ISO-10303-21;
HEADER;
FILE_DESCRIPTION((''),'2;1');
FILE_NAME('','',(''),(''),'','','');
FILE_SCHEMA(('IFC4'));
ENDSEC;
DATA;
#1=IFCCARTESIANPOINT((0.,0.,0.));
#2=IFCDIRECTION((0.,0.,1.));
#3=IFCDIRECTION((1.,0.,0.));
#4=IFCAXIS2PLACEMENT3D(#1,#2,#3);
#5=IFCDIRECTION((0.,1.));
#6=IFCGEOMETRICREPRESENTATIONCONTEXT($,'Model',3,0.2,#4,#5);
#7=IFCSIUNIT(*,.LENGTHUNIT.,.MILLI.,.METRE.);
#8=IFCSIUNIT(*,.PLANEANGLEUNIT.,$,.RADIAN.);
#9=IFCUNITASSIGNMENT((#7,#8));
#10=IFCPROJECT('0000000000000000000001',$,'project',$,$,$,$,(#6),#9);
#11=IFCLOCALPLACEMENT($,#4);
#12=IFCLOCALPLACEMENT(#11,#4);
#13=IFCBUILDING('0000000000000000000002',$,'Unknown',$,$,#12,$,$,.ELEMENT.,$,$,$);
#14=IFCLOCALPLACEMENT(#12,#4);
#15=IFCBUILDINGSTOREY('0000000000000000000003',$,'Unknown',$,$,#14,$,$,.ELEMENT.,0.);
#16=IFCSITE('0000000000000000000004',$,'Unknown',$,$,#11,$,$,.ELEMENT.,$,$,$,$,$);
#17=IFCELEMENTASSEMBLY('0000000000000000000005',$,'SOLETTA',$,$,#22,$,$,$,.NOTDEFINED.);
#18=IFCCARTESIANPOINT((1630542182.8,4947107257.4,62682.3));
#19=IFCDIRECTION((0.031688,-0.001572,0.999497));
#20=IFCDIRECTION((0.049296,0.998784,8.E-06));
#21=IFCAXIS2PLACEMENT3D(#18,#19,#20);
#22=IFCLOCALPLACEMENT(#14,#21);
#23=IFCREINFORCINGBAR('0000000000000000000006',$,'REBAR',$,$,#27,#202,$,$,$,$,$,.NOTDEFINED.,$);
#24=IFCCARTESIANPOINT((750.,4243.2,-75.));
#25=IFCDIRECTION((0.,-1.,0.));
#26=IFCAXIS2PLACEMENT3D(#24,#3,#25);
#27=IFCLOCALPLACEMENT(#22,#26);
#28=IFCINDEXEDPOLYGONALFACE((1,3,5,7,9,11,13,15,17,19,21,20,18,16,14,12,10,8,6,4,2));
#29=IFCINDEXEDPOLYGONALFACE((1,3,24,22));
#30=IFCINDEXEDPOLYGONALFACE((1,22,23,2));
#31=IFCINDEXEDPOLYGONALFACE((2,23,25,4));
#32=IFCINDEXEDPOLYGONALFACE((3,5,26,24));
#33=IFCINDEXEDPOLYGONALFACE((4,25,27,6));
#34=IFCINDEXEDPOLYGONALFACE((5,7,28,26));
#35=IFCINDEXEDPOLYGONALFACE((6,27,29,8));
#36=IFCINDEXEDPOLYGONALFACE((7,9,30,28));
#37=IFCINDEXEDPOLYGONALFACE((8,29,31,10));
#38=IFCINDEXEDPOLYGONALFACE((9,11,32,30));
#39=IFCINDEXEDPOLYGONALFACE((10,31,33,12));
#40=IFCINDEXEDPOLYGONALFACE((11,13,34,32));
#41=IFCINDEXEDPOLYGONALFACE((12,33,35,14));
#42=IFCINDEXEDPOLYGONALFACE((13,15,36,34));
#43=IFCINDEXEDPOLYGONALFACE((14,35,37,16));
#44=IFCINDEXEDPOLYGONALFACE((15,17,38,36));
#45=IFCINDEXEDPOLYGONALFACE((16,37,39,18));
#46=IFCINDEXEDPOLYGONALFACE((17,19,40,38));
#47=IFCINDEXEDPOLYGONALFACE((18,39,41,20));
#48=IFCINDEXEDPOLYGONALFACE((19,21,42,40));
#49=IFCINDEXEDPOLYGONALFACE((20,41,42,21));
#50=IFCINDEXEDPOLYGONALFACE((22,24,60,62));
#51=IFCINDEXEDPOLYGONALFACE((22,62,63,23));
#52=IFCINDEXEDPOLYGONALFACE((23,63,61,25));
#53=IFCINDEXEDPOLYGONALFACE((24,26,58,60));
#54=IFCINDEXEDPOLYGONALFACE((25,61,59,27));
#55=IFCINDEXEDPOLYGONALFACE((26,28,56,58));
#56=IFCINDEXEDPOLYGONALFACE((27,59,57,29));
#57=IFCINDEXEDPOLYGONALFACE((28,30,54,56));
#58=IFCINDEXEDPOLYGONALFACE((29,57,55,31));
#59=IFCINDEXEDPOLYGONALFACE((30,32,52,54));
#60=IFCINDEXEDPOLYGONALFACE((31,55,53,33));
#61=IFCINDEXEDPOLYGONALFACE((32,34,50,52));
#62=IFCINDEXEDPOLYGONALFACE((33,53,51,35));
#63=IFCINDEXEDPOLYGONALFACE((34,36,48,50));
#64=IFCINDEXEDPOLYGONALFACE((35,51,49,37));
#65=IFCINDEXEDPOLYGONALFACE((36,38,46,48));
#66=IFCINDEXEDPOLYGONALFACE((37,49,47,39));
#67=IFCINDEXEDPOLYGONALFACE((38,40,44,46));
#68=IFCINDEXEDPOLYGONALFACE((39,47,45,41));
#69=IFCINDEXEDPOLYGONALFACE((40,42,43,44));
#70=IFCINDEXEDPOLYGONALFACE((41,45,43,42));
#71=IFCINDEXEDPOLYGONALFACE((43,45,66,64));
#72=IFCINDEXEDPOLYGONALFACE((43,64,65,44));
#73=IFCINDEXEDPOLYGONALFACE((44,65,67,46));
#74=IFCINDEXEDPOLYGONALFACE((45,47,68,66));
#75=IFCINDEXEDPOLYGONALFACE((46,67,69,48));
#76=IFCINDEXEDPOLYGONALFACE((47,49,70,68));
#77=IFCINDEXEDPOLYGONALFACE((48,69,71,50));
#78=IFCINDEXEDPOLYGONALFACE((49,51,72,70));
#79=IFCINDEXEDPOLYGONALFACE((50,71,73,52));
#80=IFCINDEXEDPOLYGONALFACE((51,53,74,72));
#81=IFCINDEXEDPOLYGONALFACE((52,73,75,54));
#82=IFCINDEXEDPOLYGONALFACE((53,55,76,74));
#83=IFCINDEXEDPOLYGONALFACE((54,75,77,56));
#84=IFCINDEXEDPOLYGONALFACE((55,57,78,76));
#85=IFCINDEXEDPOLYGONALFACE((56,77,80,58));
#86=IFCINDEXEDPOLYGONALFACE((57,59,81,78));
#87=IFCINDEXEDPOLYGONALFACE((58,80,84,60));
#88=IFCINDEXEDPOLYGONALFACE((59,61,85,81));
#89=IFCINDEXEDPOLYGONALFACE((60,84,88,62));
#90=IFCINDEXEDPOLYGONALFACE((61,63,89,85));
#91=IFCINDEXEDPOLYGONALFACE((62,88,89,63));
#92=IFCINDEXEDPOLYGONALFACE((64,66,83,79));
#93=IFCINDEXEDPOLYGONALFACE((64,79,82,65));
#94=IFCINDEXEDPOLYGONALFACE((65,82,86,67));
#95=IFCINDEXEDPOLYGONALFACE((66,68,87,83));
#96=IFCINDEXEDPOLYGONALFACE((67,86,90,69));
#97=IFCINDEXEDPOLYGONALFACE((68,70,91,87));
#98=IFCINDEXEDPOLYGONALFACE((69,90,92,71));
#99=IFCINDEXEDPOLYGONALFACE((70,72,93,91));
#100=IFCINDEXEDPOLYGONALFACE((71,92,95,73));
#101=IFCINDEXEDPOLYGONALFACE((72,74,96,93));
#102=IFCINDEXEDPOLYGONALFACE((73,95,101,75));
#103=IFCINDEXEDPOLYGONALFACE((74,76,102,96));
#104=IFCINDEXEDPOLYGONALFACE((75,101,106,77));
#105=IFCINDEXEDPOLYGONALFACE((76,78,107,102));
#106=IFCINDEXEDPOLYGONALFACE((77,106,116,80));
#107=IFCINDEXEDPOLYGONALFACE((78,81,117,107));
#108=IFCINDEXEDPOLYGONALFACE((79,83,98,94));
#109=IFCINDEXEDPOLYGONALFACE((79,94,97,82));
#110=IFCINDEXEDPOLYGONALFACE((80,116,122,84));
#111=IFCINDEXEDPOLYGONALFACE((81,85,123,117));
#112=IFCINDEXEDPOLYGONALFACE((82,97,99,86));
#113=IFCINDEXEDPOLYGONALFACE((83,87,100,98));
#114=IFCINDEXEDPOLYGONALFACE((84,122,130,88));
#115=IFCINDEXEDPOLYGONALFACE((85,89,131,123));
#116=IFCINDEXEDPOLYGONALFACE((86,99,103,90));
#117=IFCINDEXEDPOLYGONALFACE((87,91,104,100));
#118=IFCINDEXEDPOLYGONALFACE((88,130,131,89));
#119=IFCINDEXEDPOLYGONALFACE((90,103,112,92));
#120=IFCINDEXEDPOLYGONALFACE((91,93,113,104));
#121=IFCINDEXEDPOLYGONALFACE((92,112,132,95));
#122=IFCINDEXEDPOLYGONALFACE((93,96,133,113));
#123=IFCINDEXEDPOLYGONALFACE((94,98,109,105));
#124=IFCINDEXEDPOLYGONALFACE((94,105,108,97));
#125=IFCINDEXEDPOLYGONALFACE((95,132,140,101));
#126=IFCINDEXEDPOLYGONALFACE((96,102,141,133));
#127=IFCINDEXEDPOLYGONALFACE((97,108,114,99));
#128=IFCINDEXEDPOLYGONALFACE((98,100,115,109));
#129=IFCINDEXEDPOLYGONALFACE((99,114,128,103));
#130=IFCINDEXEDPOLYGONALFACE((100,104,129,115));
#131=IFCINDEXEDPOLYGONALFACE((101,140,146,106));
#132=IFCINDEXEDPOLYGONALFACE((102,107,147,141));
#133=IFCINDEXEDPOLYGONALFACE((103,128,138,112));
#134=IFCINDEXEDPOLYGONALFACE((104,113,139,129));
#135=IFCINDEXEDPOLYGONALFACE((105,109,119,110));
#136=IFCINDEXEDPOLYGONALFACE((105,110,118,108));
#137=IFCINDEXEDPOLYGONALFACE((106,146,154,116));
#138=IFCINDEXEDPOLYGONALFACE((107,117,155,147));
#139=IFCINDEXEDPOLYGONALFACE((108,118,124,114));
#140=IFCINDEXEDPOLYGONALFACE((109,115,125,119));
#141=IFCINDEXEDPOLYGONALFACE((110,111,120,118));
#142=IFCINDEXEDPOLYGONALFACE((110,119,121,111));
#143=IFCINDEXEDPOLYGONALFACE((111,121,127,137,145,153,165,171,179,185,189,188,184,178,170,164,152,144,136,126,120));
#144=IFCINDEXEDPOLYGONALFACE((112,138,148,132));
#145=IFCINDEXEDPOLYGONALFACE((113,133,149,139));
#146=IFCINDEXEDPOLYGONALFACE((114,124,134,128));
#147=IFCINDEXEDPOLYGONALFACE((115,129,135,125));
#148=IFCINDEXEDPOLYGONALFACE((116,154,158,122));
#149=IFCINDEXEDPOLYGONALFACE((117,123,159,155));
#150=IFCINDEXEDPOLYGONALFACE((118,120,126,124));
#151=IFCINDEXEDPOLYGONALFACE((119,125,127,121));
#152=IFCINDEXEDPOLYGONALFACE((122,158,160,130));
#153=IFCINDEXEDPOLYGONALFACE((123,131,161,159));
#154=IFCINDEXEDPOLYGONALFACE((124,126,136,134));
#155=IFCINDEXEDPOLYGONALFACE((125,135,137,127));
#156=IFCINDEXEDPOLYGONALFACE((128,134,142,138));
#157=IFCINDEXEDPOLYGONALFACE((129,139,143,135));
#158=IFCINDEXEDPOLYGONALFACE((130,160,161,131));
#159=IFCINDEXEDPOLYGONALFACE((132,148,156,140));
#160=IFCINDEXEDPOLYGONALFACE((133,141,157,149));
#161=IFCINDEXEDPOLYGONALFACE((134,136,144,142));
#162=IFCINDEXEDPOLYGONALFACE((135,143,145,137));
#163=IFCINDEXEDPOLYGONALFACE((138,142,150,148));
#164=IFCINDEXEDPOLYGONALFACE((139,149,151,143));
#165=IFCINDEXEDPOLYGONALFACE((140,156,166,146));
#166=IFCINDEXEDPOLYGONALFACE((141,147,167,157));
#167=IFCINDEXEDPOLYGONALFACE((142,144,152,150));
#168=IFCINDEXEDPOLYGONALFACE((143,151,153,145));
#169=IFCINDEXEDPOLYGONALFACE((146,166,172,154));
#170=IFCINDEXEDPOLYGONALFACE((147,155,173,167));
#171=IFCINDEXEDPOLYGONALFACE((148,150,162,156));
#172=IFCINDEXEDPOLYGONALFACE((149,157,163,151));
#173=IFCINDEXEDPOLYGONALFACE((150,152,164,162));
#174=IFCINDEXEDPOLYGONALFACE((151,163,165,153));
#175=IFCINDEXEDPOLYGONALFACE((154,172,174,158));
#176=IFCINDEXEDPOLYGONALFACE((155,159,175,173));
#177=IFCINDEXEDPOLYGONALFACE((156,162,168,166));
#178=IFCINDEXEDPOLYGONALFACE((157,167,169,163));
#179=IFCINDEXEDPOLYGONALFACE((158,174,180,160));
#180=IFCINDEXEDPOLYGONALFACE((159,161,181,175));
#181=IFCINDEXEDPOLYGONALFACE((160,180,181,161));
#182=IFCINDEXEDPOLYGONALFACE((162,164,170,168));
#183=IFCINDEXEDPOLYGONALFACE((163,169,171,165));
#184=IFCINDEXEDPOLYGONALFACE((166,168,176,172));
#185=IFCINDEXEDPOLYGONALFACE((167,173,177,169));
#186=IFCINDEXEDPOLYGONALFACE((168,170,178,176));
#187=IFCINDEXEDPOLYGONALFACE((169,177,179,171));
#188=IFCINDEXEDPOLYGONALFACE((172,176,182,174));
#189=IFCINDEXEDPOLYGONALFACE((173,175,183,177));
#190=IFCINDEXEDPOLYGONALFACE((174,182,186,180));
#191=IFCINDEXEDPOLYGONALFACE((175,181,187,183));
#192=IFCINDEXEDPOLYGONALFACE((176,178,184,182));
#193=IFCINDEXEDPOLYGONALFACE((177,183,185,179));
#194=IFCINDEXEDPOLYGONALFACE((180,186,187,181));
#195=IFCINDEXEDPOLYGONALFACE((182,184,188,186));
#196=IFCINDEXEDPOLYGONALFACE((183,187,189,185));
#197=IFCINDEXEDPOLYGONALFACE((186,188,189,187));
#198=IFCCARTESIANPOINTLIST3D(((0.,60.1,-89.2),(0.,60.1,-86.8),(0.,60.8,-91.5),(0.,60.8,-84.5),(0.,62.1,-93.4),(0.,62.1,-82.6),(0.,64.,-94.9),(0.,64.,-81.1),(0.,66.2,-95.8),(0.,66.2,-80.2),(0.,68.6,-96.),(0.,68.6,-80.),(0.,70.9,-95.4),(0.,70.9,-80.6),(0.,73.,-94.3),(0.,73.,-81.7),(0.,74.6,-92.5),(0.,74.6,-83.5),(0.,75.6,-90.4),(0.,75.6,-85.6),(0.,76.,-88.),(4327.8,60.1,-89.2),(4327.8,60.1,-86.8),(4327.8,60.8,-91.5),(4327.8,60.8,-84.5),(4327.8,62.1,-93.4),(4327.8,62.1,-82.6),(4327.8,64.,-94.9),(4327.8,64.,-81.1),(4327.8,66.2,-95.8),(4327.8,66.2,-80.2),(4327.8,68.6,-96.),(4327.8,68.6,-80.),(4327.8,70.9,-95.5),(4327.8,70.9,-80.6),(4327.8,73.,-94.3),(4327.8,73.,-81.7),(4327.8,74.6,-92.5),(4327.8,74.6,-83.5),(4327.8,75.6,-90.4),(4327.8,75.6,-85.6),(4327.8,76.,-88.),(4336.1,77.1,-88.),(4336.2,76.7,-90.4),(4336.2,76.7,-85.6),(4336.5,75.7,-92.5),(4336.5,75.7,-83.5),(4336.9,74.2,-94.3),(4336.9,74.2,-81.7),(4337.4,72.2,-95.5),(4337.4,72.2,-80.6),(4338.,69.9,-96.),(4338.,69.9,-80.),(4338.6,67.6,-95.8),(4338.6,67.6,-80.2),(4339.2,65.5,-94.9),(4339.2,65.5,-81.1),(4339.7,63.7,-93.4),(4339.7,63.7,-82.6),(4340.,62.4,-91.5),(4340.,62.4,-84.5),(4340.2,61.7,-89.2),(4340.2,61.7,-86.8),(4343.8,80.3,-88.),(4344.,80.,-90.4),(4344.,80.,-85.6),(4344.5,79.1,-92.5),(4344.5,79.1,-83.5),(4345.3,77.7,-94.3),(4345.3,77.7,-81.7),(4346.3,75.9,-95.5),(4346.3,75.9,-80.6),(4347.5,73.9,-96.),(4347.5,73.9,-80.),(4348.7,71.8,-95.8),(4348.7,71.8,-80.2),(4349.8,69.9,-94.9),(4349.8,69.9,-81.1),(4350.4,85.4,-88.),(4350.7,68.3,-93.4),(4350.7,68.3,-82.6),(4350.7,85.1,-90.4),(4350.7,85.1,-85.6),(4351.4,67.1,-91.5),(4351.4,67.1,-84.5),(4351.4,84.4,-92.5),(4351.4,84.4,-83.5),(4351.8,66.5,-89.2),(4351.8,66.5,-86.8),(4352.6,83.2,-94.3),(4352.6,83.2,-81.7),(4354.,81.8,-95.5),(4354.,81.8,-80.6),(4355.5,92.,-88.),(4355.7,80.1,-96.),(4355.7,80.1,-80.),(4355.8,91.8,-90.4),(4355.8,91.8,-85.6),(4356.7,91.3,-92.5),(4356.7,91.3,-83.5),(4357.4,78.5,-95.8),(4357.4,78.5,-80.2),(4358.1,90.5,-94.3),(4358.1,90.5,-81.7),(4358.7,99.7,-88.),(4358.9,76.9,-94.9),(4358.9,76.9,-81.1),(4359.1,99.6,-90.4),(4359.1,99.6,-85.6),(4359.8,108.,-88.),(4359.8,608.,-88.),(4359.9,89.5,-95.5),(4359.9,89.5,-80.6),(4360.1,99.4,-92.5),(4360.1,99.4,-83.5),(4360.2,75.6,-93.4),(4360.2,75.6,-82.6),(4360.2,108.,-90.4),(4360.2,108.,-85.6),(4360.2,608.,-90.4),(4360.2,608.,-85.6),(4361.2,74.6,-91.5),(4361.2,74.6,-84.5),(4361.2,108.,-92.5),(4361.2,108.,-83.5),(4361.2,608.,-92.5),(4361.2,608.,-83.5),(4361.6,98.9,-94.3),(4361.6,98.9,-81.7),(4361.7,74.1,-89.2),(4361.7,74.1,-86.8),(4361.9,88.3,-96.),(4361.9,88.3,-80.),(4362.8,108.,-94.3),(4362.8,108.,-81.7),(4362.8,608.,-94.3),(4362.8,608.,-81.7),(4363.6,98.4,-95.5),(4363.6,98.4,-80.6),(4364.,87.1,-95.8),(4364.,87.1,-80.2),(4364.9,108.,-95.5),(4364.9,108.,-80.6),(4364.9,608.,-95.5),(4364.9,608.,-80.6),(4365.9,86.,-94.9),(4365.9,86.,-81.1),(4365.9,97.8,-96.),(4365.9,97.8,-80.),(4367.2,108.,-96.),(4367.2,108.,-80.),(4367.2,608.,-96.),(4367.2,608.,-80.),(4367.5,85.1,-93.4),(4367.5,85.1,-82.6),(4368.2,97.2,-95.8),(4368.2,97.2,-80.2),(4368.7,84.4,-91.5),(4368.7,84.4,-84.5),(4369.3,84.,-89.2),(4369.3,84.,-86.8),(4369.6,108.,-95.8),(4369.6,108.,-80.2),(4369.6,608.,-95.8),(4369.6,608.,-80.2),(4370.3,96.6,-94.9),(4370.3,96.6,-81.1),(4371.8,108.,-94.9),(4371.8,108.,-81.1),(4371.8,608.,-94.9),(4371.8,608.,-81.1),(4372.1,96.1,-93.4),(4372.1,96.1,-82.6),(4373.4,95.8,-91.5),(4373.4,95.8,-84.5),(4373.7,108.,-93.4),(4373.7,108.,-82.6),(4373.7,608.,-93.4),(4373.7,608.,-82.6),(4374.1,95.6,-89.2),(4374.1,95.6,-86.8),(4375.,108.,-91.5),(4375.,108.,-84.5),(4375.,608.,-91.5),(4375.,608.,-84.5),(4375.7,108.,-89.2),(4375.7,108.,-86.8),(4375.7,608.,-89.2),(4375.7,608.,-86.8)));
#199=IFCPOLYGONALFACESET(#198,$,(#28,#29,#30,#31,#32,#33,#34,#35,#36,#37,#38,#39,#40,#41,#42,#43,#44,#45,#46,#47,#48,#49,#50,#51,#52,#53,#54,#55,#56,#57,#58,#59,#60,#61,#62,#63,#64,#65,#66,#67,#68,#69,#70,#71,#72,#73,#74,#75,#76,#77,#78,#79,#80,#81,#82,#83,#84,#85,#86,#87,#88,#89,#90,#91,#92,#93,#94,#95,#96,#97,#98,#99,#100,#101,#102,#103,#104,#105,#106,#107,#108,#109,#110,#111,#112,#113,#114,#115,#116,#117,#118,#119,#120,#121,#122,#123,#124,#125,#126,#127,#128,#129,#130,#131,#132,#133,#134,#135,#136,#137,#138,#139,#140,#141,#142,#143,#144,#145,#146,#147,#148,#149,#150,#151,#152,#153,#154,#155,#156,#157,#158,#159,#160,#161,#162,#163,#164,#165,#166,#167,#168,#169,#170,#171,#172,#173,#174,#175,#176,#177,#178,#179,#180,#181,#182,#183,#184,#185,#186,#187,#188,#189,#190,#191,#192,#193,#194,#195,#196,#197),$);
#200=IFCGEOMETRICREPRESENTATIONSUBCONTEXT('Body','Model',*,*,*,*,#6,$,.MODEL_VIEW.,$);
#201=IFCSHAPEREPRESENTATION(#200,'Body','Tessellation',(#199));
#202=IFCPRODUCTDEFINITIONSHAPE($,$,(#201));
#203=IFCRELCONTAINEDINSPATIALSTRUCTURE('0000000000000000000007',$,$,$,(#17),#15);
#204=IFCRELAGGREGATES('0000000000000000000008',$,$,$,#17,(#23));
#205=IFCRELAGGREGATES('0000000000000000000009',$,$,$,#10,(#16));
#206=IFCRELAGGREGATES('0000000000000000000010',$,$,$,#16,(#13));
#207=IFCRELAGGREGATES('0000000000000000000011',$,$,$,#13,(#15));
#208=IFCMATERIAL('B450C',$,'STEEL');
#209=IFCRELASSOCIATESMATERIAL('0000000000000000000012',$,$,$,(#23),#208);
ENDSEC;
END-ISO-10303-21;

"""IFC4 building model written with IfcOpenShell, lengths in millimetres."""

from ifc_helpers import new_model, entity, si_unit, direction, frame, origin_with_axes, place, context, subcontext, project, spatial, material, element, aggregate, save


model = new_model("IFC4")

# Units and contexts
model_context = context("Model", 3, precision=0.2, world=origin_with_axes(), true_north=direction((0.0, 1.0)))
body_context = subcontext(model_context, "Body", "Model", "MODEL_VIEW")
ifc_project = project(units=[si_unit("LENGTHUNIT", "METRE", prefix="MILLI"), si_unit("PLANEANGLEUNIT", "RADIAN")], contexts=[model_context])

# Site, building, storey
site_placement = place(None, origin_with_axes())
site = spatial("IfcSite", under=ifc_project, at=site_placement, Name="Unknown", CompositionType="ELEMENT")
building_placement = place(site_placement, origin_with_axes())
building = spatial("IfcBuilding", under=site, at=building_placement, Name="Unknown", CompositionType="ELEMENT")
storey_placement = place(building_placement, origin_with_axes())
storey = spatial("IfcBuildingStorey", under=building, at=storey_placement, Name="Unknown", CompositionType="ELEMENT", Elevation=0.0)

# Element assembly, reinforcing bar
ifc_material = material(Name="B450C", Category="STEEL")
assembly_1_placement = place(storey_placement, frame((1630542182.8, 4947107257.4, 62682.3), z_axis=(0.031688, -0.001572, 0.999497), x_axis=(0.049296, 0.998784, 0.000008)))
assembly_1 = element("IfcElementAssembly", 1, at=assembly_1_placement, inside=storey, Name="SOLETTA", PredefinedType="NOTDEFINED")
reinforcing_bar_1_placement = place(assembly_1_placement, frame((750.0, 4243.2, -75.0), z_axis=(1.0, 0.0, 0.0), x_axis=(0.0, -1.0, 0.0)))
reinforcing_bar_1 = element("IfcReinforcingBar", 2, at=reinforcing_bar_1_placement, material=ifc_material, Name="REBAR", PredefinedType="NOTDEFINED", context=body_context, shape_type="AdvancedSweptSolid", body=[
    entity("IfcSweptDiskSolid", entity("IfcIndexedPolyCurve", entity("IfcCartesianPointList3D", [[0.0, 68.0, -88.0], [4327.8, 68.0, -88.0], [4356.1, 79.7, -88.0], [4367.8, 108.0, -88.0], [4367.8, 608.0, -88.0]]), [entity("IfcLineIndex", [1, 2]), entity("IfcArcIndex", [2, 3, 4]), entity("IfcLineIndex", [4, 5])]), 8.0),
])
aggregate(assembly_1, [reinforcing_bar_1])

save(model, "model.ifc")
